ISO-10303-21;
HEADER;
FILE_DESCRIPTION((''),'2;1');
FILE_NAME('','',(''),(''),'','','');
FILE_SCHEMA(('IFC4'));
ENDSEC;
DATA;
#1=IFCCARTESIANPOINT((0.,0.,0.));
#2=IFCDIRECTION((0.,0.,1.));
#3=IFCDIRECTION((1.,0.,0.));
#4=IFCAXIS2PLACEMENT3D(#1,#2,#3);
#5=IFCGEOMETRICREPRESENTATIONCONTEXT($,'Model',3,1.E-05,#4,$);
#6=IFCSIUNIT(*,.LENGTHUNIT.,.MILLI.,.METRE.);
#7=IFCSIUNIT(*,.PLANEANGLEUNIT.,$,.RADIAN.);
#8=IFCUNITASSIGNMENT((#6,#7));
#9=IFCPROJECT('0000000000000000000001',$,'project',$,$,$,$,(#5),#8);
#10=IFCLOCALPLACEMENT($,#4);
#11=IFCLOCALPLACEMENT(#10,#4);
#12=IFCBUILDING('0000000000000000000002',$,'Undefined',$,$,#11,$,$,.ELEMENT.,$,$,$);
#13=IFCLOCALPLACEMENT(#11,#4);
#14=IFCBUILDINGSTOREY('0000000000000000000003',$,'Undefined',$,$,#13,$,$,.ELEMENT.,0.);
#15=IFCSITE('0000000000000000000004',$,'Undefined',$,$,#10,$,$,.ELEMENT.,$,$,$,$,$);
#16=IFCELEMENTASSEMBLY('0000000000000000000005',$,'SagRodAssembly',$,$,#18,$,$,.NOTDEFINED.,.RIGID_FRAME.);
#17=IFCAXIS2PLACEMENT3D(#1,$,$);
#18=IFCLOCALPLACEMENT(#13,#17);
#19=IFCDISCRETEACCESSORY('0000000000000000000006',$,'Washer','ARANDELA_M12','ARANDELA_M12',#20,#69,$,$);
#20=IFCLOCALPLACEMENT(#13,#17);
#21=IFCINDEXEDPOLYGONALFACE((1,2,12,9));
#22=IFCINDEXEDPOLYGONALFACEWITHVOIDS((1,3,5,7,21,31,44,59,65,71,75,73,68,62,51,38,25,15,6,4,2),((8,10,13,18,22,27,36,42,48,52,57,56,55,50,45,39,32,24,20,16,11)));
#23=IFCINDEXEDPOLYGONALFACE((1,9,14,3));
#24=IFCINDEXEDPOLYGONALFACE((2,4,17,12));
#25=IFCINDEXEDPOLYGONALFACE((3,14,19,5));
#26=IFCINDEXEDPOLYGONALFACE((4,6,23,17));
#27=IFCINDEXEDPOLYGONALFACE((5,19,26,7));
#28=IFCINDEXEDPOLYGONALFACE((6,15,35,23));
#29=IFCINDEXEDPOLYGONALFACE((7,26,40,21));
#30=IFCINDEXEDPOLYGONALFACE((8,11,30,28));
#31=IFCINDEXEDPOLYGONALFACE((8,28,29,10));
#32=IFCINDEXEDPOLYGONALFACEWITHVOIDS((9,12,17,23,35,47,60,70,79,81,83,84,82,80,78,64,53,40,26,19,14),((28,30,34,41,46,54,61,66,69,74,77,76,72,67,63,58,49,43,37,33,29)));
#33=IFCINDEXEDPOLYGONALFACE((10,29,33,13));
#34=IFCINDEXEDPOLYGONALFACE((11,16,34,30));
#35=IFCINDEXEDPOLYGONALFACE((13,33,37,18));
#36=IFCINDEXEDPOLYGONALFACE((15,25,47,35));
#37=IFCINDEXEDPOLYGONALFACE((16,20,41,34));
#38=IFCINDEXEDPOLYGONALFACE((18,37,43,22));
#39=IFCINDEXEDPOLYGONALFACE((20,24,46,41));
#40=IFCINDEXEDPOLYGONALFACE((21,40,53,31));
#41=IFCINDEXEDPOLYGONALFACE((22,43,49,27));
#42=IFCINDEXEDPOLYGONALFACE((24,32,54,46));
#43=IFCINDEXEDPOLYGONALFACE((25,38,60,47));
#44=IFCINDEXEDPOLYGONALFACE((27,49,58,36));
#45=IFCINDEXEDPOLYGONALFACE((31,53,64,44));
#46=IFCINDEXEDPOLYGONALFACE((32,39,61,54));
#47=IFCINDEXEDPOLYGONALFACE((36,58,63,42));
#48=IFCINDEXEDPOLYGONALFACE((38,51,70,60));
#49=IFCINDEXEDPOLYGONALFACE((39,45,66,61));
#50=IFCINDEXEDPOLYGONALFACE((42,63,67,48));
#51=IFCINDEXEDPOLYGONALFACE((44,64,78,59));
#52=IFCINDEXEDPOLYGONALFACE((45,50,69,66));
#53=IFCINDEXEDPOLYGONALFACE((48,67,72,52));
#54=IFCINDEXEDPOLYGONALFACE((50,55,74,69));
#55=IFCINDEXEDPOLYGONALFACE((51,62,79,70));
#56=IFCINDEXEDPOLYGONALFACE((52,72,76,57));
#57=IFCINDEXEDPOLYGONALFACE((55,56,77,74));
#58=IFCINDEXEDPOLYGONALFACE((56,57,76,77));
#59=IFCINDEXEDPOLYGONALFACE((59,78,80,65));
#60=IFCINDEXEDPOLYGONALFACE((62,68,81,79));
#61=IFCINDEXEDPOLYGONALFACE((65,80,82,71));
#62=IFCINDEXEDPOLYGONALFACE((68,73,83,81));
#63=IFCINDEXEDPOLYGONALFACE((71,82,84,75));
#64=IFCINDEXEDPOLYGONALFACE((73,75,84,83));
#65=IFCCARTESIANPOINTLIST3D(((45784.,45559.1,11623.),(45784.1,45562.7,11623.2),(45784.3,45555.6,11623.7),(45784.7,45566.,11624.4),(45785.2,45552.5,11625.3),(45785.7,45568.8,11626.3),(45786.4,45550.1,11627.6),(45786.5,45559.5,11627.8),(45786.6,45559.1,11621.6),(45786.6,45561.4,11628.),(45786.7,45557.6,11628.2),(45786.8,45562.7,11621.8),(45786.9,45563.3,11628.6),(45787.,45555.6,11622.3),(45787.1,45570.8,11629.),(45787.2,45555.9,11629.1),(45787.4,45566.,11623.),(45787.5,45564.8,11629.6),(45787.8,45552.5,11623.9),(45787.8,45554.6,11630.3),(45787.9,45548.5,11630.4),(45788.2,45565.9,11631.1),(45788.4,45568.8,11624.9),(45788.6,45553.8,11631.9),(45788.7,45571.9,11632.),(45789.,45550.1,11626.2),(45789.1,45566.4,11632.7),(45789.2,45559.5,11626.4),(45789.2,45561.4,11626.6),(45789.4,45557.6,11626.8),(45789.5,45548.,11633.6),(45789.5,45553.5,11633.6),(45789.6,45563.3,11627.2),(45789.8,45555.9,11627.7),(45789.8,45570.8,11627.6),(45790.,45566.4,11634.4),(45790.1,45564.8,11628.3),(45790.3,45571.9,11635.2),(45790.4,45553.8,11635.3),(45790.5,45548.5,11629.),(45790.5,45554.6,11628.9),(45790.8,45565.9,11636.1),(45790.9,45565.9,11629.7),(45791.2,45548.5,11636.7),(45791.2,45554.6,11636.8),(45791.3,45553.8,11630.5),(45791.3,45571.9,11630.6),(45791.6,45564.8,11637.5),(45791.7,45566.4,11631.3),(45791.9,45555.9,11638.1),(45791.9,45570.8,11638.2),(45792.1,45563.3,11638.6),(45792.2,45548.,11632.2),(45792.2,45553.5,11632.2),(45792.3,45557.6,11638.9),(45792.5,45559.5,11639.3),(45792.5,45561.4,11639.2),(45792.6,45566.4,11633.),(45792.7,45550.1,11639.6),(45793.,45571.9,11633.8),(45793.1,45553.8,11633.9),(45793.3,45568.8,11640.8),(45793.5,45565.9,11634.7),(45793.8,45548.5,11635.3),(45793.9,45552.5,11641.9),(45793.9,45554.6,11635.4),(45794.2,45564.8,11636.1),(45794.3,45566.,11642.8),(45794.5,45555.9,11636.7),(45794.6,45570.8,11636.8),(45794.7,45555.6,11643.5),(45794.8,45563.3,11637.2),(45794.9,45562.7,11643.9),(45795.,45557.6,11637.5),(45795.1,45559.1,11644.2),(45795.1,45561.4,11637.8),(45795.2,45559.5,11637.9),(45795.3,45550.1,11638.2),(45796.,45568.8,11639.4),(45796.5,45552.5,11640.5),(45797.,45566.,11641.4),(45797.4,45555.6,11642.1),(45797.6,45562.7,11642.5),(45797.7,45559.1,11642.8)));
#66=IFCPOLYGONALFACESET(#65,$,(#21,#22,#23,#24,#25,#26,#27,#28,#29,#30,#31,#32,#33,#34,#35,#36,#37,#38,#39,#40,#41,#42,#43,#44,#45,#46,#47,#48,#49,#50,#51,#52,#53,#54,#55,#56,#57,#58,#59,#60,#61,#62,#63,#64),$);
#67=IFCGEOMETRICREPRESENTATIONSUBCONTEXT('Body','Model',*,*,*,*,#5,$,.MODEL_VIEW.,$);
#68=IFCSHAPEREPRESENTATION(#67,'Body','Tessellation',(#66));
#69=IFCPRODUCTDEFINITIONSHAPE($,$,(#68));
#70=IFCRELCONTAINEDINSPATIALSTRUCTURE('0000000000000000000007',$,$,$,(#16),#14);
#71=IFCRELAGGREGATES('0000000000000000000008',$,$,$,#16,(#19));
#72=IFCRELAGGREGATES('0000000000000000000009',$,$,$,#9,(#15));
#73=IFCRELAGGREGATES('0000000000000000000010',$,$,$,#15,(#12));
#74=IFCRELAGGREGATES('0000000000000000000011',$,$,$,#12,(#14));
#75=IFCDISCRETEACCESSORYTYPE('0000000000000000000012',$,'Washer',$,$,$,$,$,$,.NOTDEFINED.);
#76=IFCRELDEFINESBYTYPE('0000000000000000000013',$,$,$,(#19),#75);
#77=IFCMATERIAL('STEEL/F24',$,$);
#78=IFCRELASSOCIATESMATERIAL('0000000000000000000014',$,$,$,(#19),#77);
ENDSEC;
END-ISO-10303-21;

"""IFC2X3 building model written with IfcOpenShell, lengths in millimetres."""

from ifc_helpers import new_model, si_unit, frame, origin_with_axes, origin_2d_with_axis, place, context, subcontext, project, spatial, hollow_circle, extrude, material, type_object, element, aggregate, save


model = new_model("IFC2X3")

# Units and contexts
model_context = context("Model", 3, precision=1e-05, world=origin_with_axes())
body_context = subcontext(model_context, "Body", "Model", "MODEL_VIEW")
ifc_project = project(units=[si_unit("LENGTHUNIT", "METRE", prefix="MILLI"), si_unit("PLANEANGLEUNIT", "RADIAN")], contexts=[model_context])

# Site, building, storey
site_placement = place(None, origin_with_axes())
site = spatial("IfcSite", under=ifc_project, at=site_placement, Name="Undefined", CompositionType="ELEMENT")
building_placement = place(site_placement, origin_with_axes())
building = spatial("IfcBuilding", under=site, at=building_placement, Name="Undefined", CompositionType="ELEMENT")
storey_placement = place(building_placement, origin_with_axes())
storey = spatial("IfcBuildingStorey", under=building, at=storey_placement, Name="Undefined", CompositionType="ELEMENT", Elevation=0.0)

# Shared definitions
ifc_material_1 = material(Name="STEEL/F24")

# Element assembly
assembly_1_placement = place(storey_placement, origin_with_axes())
assembly_1 = element("IfcElementAssembly", 1, at=assembly_1_placement, inside=storey, Name="SagRodAssembly", AssemblyPlace="NOTDEFINED", PredefinedType="RIGID_FRAME")

# Discrete accessory
discrete_accessory_type_1 = type_object("IfcDiscreteAccessoryType", Name="Washer")
discrete_accessory_1_placement = place(assembly_1_placement, frame((45792.2, 45560.0, 11632.2), z_axis=(-0.463578, 0.0, -0.886056), x_axis=(-0.886056, 0.0, 0.463578)))
discrete_accessory_1 = element("IfcDiscreteAccessory", 2, at=discrete_accessory_1_placement, type_object=discrete_accessory_type_1, material=ifc_material_1, Name="Washer", Description="ARANDELA_M12", ObjectType="ARANDELA_M12", context=body_context, shape_type="SweptSolid", body=[
    extrude(hollow_circle(Radius=12.0, WallThickness=5.5, at=origin_2d_with_axis()), frame((3.0, 0.0, 0.0), z_axis=(-1.0, 0.0, 0.0), x_axis=(0.0, -1.0, 0.0)), (0.0, 0.0, 1.0), 3.0),
])
aggregate(assembly_1, [discrete_accessory_1])

save(model, "model.ifc")
